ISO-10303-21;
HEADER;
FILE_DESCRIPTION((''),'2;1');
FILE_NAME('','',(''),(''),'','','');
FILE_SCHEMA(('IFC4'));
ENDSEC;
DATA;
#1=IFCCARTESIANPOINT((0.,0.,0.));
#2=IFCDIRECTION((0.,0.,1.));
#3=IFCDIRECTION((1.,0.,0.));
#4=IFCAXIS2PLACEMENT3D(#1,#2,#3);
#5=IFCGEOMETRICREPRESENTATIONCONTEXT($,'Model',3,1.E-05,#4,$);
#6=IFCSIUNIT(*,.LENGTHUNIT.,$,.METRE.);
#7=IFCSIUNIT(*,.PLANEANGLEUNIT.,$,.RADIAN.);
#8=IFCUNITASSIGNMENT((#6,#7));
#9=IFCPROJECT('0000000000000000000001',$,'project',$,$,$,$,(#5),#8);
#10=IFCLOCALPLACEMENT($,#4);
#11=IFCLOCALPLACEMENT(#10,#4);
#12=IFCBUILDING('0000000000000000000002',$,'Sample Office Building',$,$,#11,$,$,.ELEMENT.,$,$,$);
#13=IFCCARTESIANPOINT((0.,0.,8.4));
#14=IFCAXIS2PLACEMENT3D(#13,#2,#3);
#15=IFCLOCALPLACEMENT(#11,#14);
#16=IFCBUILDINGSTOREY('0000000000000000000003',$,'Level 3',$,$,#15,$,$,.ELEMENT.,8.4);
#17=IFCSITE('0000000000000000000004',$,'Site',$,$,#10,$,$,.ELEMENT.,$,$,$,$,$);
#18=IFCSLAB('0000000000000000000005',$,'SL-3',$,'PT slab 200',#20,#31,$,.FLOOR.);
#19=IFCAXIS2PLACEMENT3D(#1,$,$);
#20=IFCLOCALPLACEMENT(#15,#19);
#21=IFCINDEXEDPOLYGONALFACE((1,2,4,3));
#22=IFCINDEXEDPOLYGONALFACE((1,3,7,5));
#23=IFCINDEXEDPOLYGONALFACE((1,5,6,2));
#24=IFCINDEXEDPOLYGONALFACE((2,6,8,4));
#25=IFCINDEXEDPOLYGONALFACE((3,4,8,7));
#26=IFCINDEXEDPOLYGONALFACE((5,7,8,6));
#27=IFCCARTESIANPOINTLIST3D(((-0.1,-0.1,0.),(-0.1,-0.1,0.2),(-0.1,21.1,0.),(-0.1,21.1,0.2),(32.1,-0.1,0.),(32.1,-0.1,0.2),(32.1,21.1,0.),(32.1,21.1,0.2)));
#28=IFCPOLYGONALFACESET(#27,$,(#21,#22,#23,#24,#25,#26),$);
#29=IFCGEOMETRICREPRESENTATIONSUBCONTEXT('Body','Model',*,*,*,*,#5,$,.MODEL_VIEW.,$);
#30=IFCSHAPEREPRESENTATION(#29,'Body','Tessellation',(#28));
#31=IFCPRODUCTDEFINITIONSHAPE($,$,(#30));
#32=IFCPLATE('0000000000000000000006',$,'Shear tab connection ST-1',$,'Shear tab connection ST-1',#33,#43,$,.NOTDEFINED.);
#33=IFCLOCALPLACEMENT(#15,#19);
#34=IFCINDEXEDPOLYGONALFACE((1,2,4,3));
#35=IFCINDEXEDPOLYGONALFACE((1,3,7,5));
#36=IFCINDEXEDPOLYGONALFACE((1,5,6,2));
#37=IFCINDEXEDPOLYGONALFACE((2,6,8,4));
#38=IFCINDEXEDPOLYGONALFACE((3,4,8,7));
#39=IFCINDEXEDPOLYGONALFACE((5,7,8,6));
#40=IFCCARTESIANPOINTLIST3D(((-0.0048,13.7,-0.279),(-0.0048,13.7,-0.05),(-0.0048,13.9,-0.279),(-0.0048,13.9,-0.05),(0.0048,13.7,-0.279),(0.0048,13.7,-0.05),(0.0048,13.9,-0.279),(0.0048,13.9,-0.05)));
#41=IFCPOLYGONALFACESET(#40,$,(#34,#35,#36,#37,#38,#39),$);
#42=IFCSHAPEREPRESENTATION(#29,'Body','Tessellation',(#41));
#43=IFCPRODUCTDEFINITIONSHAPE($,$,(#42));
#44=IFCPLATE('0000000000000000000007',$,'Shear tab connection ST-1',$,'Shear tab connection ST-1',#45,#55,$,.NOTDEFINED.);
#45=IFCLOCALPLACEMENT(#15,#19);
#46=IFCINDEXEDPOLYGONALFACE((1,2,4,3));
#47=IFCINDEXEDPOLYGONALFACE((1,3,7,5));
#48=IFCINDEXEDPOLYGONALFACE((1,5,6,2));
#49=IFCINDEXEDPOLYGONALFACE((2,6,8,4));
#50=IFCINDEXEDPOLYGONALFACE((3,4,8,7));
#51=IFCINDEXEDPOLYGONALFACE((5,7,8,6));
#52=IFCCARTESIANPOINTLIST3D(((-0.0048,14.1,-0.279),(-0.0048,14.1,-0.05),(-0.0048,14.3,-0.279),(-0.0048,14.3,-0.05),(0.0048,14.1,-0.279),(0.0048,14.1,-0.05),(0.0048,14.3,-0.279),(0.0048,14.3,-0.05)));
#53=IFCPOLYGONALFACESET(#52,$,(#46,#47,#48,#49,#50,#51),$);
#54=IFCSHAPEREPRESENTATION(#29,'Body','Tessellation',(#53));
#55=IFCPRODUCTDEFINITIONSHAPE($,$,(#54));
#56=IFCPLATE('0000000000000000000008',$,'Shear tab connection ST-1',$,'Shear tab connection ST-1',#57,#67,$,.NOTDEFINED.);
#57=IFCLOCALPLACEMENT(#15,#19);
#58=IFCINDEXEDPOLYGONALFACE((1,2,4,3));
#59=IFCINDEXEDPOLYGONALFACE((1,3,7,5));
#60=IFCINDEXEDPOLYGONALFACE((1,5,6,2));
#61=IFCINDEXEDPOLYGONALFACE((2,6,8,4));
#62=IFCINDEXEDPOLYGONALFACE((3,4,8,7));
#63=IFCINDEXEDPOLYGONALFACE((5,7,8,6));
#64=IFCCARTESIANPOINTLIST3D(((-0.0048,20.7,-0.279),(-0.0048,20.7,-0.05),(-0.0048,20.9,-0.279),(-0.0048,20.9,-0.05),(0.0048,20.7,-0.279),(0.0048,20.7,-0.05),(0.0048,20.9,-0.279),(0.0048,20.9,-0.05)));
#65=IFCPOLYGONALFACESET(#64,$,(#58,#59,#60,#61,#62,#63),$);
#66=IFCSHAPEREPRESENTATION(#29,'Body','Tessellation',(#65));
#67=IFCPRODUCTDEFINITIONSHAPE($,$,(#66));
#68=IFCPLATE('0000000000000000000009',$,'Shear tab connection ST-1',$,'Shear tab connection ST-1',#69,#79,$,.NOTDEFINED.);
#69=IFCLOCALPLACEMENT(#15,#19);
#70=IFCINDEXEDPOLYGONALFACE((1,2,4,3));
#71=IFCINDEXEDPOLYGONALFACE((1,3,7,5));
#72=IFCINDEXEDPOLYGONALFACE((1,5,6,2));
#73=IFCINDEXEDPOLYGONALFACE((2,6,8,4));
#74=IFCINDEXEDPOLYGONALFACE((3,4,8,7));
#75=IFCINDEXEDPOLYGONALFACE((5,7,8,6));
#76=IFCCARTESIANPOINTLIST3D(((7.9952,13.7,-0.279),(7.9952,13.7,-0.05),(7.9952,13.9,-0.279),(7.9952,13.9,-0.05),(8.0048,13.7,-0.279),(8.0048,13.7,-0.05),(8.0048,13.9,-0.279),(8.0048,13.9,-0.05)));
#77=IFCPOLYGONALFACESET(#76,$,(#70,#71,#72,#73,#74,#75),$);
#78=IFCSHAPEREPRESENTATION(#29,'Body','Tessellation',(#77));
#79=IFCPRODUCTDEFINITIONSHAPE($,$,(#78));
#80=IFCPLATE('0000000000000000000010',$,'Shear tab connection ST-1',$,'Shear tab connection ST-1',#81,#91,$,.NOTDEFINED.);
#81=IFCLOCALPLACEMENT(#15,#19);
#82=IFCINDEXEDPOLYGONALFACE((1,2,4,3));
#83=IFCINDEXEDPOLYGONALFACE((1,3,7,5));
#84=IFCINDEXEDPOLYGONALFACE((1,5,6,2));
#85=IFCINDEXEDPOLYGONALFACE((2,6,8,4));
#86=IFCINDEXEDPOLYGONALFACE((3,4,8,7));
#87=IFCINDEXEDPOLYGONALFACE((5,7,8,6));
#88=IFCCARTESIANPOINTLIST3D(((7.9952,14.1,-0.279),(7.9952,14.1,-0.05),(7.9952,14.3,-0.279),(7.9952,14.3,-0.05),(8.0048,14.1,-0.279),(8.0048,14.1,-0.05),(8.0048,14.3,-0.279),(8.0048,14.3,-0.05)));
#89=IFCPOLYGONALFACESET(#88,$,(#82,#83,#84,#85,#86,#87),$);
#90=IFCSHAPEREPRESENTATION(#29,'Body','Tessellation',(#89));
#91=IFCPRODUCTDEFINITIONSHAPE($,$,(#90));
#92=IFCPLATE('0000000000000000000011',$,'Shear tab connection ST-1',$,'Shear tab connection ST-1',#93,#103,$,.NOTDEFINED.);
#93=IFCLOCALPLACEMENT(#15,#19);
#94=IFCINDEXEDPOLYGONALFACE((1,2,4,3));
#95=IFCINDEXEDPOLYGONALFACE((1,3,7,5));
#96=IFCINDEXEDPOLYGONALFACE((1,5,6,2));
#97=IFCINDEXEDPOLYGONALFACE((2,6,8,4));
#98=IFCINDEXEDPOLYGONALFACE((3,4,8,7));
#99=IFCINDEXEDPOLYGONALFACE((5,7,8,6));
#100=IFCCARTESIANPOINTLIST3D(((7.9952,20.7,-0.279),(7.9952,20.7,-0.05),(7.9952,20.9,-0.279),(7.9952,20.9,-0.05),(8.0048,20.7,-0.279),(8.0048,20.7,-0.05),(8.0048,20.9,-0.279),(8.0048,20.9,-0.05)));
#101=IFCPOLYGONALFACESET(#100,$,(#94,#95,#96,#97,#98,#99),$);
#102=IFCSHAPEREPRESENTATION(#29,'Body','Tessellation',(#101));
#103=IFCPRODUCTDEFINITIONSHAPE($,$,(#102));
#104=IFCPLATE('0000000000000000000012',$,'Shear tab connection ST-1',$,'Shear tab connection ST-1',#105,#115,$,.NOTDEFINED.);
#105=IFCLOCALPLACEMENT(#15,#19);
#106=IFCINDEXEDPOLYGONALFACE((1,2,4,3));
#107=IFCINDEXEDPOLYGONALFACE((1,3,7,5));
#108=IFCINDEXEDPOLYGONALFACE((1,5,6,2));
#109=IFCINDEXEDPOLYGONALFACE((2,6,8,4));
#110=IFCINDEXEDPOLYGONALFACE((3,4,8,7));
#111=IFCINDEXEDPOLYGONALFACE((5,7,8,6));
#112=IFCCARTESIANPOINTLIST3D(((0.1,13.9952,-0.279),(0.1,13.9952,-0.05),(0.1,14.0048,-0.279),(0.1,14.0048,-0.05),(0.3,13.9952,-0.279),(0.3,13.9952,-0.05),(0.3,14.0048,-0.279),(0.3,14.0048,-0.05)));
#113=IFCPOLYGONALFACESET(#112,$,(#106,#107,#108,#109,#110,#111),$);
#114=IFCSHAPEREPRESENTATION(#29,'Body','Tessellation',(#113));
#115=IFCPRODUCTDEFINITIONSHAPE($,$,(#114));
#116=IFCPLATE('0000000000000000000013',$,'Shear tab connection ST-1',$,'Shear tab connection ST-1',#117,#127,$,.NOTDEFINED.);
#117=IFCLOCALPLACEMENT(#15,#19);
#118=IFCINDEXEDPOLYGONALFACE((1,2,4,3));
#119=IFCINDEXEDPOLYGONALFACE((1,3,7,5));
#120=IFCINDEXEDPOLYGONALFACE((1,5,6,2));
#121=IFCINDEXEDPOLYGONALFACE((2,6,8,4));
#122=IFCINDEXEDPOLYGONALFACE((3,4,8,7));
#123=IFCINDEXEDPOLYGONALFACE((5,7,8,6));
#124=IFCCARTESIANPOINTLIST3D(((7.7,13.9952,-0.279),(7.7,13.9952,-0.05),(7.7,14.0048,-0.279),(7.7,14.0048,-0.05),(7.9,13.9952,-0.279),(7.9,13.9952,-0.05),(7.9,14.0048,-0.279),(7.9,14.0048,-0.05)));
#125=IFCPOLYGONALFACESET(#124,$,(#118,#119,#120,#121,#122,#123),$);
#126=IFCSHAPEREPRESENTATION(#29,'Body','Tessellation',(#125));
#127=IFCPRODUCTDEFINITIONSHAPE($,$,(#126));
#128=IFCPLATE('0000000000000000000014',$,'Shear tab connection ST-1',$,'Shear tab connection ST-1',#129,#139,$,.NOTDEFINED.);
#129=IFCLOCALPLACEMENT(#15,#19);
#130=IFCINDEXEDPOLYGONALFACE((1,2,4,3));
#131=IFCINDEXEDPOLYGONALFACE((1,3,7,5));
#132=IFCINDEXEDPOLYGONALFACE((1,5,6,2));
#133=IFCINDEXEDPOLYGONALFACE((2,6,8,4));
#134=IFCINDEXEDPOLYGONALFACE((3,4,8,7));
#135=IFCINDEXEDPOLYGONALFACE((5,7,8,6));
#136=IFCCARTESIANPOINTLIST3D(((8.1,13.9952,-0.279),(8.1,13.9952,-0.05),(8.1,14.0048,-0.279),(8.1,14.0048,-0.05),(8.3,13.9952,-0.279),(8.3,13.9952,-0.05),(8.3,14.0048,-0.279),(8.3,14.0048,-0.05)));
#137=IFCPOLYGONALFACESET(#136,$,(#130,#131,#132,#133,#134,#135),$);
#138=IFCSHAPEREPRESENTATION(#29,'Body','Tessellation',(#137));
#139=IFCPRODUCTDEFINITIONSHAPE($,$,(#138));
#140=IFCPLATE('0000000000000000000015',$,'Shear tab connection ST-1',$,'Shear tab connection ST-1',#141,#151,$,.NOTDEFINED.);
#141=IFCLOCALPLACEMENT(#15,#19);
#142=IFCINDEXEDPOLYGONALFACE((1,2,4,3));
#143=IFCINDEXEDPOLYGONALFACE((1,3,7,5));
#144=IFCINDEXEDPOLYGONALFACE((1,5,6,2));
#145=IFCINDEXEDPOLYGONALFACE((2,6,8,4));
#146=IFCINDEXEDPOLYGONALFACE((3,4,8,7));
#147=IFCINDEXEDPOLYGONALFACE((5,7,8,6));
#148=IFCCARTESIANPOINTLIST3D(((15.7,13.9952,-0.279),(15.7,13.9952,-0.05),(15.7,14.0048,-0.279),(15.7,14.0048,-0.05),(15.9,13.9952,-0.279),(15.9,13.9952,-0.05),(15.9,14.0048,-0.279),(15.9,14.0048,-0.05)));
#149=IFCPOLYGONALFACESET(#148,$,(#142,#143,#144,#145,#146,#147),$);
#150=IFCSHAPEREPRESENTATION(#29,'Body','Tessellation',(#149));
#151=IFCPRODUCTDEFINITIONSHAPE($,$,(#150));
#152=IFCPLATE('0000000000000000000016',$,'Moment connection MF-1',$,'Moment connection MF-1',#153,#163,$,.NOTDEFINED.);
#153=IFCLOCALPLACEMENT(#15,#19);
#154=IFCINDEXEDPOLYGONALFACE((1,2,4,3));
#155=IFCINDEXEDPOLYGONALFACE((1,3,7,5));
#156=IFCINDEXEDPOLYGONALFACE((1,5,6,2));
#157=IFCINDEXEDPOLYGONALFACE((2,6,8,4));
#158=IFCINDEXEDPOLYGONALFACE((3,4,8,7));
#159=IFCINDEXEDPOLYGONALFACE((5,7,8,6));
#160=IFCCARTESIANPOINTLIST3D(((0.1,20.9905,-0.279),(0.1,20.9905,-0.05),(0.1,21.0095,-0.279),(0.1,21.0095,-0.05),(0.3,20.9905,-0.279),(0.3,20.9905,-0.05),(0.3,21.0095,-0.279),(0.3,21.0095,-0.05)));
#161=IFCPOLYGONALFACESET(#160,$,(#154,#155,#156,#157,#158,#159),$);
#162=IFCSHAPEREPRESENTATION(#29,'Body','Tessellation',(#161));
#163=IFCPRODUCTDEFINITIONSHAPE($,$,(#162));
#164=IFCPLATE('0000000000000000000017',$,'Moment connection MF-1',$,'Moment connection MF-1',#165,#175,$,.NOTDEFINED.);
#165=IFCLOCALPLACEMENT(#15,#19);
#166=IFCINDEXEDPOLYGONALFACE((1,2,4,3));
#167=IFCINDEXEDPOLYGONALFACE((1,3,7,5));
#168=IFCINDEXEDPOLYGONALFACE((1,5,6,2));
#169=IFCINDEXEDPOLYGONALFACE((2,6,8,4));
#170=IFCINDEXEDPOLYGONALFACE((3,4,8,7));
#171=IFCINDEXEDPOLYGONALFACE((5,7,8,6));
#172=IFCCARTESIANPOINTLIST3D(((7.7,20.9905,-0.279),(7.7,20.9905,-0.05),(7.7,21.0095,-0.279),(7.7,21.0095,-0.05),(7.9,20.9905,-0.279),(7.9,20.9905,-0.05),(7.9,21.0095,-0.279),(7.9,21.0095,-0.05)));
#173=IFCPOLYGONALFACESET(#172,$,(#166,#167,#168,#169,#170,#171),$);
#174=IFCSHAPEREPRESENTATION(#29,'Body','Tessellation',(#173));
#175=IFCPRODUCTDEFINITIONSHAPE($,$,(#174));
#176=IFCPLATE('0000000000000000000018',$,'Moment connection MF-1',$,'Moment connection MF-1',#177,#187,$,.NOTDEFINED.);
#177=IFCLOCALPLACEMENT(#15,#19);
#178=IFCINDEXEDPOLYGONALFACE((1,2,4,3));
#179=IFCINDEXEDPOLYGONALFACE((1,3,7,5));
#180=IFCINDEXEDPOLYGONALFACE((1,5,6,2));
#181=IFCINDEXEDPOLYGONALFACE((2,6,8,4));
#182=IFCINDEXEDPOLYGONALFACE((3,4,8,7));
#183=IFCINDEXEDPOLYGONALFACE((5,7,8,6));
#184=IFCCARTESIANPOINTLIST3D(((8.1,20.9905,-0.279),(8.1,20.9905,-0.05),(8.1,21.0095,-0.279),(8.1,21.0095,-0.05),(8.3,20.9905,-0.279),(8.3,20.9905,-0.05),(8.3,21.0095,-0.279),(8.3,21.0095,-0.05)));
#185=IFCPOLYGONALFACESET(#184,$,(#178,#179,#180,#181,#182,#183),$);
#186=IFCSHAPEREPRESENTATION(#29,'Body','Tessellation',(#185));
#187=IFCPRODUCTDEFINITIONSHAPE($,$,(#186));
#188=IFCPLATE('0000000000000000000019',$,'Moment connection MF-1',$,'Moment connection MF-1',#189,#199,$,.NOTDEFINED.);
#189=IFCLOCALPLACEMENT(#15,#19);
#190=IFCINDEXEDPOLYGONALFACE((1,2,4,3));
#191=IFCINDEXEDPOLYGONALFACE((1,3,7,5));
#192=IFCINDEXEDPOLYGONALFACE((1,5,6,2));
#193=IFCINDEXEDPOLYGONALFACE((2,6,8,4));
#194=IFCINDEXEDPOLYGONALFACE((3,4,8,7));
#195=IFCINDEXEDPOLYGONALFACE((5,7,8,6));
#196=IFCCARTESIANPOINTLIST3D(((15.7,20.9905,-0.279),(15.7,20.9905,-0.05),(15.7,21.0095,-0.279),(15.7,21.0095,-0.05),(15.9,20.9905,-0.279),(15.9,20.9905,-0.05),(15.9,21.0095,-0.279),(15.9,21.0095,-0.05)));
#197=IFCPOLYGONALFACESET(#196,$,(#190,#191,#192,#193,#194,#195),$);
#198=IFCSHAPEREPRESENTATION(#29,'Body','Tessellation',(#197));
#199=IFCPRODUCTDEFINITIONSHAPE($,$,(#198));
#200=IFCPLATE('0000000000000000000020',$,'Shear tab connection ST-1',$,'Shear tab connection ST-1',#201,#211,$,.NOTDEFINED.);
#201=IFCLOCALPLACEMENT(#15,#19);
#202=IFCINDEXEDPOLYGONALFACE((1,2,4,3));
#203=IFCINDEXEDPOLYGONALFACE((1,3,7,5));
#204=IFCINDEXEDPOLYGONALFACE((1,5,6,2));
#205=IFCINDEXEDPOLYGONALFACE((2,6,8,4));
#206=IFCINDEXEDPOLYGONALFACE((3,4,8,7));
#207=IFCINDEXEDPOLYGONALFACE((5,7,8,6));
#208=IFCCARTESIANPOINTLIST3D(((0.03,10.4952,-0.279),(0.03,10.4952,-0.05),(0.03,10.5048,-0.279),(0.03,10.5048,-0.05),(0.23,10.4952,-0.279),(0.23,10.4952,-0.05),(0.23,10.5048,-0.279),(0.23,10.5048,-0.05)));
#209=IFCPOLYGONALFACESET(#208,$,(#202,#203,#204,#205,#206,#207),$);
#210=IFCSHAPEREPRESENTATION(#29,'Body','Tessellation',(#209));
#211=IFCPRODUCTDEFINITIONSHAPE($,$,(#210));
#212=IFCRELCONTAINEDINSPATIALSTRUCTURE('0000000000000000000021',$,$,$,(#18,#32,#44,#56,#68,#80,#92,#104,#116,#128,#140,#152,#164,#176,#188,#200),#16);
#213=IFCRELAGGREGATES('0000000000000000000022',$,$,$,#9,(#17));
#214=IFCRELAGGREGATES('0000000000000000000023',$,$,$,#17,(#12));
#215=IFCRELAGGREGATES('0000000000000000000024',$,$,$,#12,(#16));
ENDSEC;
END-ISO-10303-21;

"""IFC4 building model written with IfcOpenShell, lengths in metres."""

from ifc_helpers import new_model, si_unit, frame, origin_with_axes, place, context, subcontext, project, spatial, rectangle, extrude, element, save


model = new_model("IFC4")

# Units and contexts
model_context = context("Model", 3, precision=1e-05, world=origin_with_axes())
body_context = subcontext(model_context, "Body", "Model", "MODEL_VIEW")
ifc_project = project(units=[si_unit("LENGTHUNIT", "METRE"), si_unit("PLANEANGLEUNIT", "RADIAN")], contexts=[model_context])

# Site, building, storey
site_placement = place(None, origin_with_axes())
site = spatial("IfcSite", under=ifc_project, at=site_placement, Name="Site", CompositionType="ELEMENT")
building_placement = place(site_placement, origin_with_axes())
building = spatial("IfcBuilding", under=site, at=building_placement, Name="Sample Office Building", CompositionType="ELEMENT")
storey_placement = place(building_placement, frame((0.0, 0.0, 8.4), z_axis=(0.0, 0.0, 1.0), x_axis=(1.0, 0.0, 0.0)))
storey = spatial("IfcBuildingStorey", under=building, at=storey_placement, Name="Level 3", CompositionType="ELEMENT", Elevation=8.4)

# Slab
slab_placement = place(None, frame((16.0, 10.5, 8.4), z_axis=(0.0, 0.0, 1.0), x_axis=(1.0, 0.0, 0.0)))
element("IfcSlab", 1, at=slab_placement, inside=storey, Name="SL-3", ObjectType="PT slab 200", PredefinedType="FLOOR", context=body_context, shape_type="SweptSolid", body=[
    extrude(rectangle(XDim=32.2, YDim=21.2), None, (0.0, 0.0, 1.0), 0.2),
])

# Plates
for number, where, z_axis, x_axis, name in (
    (2, (0.0, 13.8, 8.121), (0.0, 0.0, 1.0), (1.0, 0.0, 0.0), "Shear tab connection ST-1"),
    (3, (0.0, 14.2, 8.121), (0.0, 0.0, 1.0), (1.0, 0.0, 0.0), "Shear tab connection ST-1"),
):
    element("IfcPlate", number, at=place(None, frame(where, z_axis=z_axis, x_axis=x_axis)), inside=storey, Name=name, ObjectType="Shear tab connection ST-1", PredefinedType="NOTDEFINED", context=body_context, shape_type="SweptSolid", body=[
        extrude(rectangle(XDim=0.0095, YDim=0.2), None, (0.0, 0.0, 1.0), 0.229),
    ])
plate_1_placement = place(None, frame((0.0, 20.8, 8.121), z_axis=(0.0, 0.0, 1.0), x_axis=(1.0, 0.0, 0.0)))
element("IfcPlate", 4, at=plate_1_placement, inside=storey, Name="Shear tab connection ST-1", ObjectType="Shear tab connection ST-1", PredefinedType="NOTDEFINED", context=body_context, shape_type="SweptSolid", body=[
    extrude(rectangle(XDim=0.0095, YDim=0.2), None, (0.0, 0.0, 1.0), 0.229),
])
for number, where, z_axis, x_axis, name in (
    (5, (8.0, 13.8, 8.121), (0.0, 0.0, 1.0), (1.0, 0.0, 0.0), "Shear tab connection ST-1"),
    (6, (8.0, 14.2, 8.121), (0.0, 0.0, 1.0), (1.0, 0.0, 0.0), "Shear tab connection ST-1"),
):
    element("IfcPlate", number, at=place(None, frame(where, z_axis=z_axis, x_axis=x_axis)), inside=storey, Name=name, ObjectType="Shear tab connection ST-1", PredefinedType="NOTDEFINED", context=body_context, shape_type="SweptSolid", body=[
        extrude(rectangle(XDim=0.0095, YDim=0.2), None, (0.0, 0.0, 1.0), 0.229),
    ])
plate_2_placement = place(None, frame((8.0, 20.8, 8.121), z_axis=(0.0, 0.0, 1.0), x_axis=(1.0, 0.0, 0.0)))
element("IfcPlate", 7, at=plate_2_placement, inside=storey, Name="Shear tab connection ST-1", ObjectType="Shear tab connection ST-1", PredefinedType="NOTDEFINED", context=body_context, shape_type="SweptSolid", body=[
    extrude(rectangle(XDim=0.0095, YDim=0.2), None, (0.0, 0.0, 1.0), 0.229),
])
plate_3_placement = place(None, frame((0.2, 14.0, 8.121), z_axis=(0.0, 0.0, 1.0), x_axis=(1.0, 0.0, 0.0)))
element("IfcPlate", 8, at=plate_3_placement, inside=storey, Name="Shear tab connection ST-1", ObjectType="Shear tab connection ST-1", PredefinedType="NOTDEFINED", context=body_context, shape_type="SweptSolid", body=[
    extrude(rectangle(XDim=0.2, YDim=0.0095), None, (0.0, 0.0, 1.0), 0.229),
])
plate_4_placement = place(None, frame((7.8, 14.0, 8.121), z_axis=(0.0, 0.0, 1.0), x_axis=(1.0, 0.0, 0.0)))
element("IfcPlate", 9, at=plate_4_placement, inside=storey, Name="Shear tab connection ST-1", ObjectType="Shear tab connection ST-1", PredefinedType="NOTDEFINED", context=body_context, shape_type="SweptSolid", body=[
    extrude(rectangle(XDim=0.2, YDim=0.0095), None, (0.0, 0.0, 1.0), 0.229),
])
for number, where, z_axis, x_axis, name in (
    (10, (8.2, 14.0, 8.121), (0.0, 0.0, 1.0), (1.0, 0.0, 0.0), "Shear tab connection ST-1"),
    (11, (15.8, 14.0, 8.121), (0.0, 0.0, 1.0), (1.0, 0.0, 0.0), "Shear tab connection ST-1"),
):
    element("IfcPlate", number, at=place(None, frame(where, z_axis=z_axis, x_axis=x_axis)), inside=storey, Name=name, ObjectType="Shear tab connection ST-1", PredefinedType="NOTDEFINED", context=body_context, shape_type="SweptSolid", body=[
        extrude(rectangle(XDim=0.2, YDim=0.0095), None, (0.0, 0.0, 1.0), 0.229),
    ])
plate_5_placement = place(None, frame((0.2, 21.0, 8.121), z_axis=(0.0, 0.0, 1.0), x_axis=(1.0, 0.0, 0.0)))
element("IfcPlate", 12, at=plate_5_placement, inside=storey, Name="Moment connection MF-1", ObjectType="Moment connection MF-1", PredefinedType="NOTDEFINED", context=body_context, shape_type="SweptSolid", body=[
    extrude(rectangle(XDim=0.2, YDim=0.019), None, (0.0, 0.0, 1.0), 0.229),
])
plate_6_placement = place(None, frame((7.8, 21.0, 8.121), z_axis=(0.0, 0.0, 1.0), x_axis=(1.0, 0.0, 0.0)))
element("IfcPlate", 13, at=plate_6_placement, inside=storey, Name="Moment connection MF-1", ObjectType="Moment connection MF-1", PredefinedType="NOTDEFINED", context=body_context, shape_type="SweptSolid", body=[
    extrude(rectangle(XDim=0.2, YDim=0.019), None, (0.0, 0.0, 1.0), 0.229),
])
for number, where, z_axis, x_axis, name in (
    (14, (8.2, 21.0, 8.121), (0.0, 0.0, 1.0), (1.0, 0.0, 0.0), "Moment connection MF-1"),
    (15, (15.8, 21.0, 8.121), (0.0, 0.0, 1.0), (1.0, 0.0, 0.0), "Moment connection MF-1"),
):
    element("IfcPlate", number, at=place(None, frame(where, z_axis=z_axis, x_axis=x_axis)), inside=storey, Name=name, ObjectType="Moment connection MF-1", PredefinedType="NOTDEFINED", context=body_context, shape_type="SweptSolid", body=[
        extrude(rectangle(XDim=0.2, YDim=0.019), None, (0.0, 0.0, 1.0), 0.229),
    ])
plate_7_placement = place(None, frame((0.13, 10.5, 8.121), z_axis=(0.0, 0.0, 1.0), x_axis=(1.0, 0.0, 0.0)))
element("IfcPlate", 16, at=plate_7_placement, inside=storey, Name="Shear tab connection ST-1", ObjectType="Shear tab connection ST-1", PredefinedType="NOTDEFINED", context=body_context, shape_type="SweptSolid", body=[
    extrude(rectangle(XDim=0.2, YDim=0.0095), None, (0.0, 0.0, 1.0), 0.229),
])

save(model, "model.ifc")
